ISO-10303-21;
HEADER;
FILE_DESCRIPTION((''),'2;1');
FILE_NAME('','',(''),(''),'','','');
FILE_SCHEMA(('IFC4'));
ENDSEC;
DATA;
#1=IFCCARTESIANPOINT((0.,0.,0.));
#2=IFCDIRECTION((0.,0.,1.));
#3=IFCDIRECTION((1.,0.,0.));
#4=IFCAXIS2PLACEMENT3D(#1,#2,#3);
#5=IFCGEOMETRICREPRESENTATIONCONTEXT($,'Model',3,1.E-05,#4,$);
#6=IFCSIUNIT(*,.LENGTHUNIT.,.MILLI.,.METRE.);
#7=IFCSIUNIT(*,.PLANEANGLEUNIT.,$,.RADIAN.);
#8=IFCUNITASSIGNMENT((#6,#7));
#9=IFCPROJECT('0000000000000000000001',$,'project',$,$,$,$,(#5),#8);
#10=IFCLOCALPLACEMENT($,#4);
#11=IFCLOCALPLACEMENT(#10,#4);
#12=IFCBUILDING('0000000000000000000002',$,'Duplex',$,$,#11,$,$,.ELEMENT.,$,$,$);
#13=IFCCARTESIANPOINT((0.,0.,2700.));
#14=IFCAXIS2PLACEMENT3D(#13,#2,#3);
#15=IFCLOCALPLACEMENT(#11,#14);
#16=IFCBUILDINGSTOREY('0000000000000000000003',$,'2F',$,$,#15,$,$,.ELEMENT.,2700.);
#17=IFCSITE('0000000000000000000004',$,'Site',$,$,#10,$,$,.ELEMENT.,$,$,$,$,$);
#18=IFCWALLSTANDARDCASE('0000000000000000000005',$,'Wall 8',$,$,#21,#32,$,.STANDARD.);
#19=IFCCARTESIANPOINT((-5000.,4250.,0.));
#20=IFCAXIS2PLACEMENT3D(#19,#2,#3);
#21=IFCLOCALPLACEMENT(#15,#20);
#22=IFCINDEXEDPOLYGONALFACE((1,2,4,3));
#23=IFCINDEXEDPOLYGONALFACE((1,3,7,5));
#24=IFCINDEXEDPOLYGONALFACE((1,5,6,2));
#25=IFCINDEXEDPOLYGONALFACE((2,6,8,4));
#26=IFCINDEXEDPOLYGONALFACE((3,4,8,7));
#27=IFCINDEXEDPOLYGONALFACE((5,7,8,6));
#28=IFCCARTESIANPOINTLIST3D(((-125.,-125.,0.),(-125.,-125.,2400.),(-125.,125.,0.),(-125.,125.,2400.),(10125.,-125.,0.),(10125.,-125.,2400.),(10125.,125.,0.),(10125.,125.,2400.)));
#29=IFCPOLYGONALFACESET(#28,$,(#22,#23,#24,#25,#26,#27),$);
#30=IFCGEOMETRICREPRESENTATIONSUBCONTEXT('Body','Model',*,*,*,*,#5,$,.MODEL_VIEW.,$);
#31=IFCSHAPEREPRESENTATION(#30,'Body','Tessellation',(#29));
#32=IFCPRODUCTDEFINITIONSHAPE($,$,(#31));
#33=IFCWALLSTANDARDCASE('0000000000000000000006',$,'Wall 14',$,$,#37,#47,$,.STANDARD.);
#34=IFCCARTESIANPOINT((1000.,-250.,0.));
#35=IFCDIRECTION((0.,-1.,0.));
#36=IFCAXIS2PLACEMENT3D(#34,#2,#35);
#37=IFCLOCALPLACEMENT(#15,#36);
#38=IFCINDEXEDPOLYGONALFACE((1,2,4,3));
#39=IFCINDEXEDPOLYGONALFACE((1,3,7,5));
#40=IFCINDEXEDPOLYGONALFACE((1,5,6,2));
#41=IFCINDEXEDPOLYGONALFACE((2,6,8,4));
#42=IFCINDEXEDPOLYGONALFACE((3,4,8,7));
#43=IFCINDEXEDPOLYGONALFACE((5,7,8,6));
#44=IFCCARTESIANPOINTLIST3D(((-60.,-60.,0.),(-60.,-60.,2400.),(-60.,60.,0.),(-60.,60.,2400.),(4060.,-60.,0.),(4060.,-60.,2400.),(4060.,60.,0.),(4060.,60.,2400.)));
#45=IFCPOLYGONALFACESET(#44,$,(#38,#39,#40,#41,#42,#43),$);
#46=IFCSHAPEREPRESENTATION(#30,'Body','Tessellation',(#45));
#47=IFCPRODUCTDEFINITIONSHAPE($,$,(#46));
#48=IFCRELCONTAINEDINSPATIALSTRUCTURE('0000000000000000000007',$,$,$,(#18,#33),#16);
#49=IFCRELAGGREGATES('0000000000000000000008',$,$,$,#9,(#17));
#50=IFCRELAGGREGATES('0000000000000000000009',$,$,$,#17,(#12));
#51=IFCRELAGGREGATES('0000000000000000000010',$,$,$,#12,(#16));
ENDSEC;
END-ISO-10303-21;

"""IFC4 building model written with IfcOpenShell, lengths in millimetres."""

from ifc_helpers import new_model, si_unit, frame, frame_2d, origin, origin_with_axes, place, context, subcontext, project, spatial, rectangle, extrude, element, save


model = new_model("IFC4")

# Units and contexts
model_context = context("Model", 3, precision=1e-05, world=origin_with_axes())
body_context = subcontext(model_context, "Body", "Model", "MODEL_VIEW")
ifc_project = project(units=[si_unit("LENGTHUNIT", "METRE", prefix="MILLI"), si_unit("PLANEANGLEUNIT", "RADIAN")], contexts=[model_context])

# Site, building, storey
site_placement = place(None, origin_with_axes())
site = spatial("IfcSite", under=ifc_project, at=site_placement, Name="Site", CompositionType="ELEMENT")
building_placement = place(site_placement, origin_with_axes())
building = spatial("IfcBuilding", under=site, at=building_placement, Name="Duplex", CompositionType="ELEMENT")
storey_placement = place(building_placement, frame((0.0, 0.0, 2700.0), z_axis=(0.0, 0.0, 1.0), x_axis=(1.0, 0.0, 0.0)))
storey = spatial("IfcBuildingStorey", under=building, at=storey_placement, Name="2F", CompositionType="ELEMENT", Elevation=2700.0)

# Wall
wall_1_placement = place(storey_placement, frame((-5000.0, 4250.0, 0.0), z_axis=(0.0, 0.0, 1.0), x_axis=(1.0, 0.0, 0.0)))
element("IfcWallStandardCase", 1, at=wall_1_placement, inside=storey, Name="Wall 8", PredefinedType="STANDARD", context=body_context, shape_type="SweptSolid", body=[
    extrude(rectangle(XDim=10250.0, YDim=250.0, at=frame_2d((5000.0, 0.0))), origin(), (0.0, 0.0, 1.0), 2400.0),
])

# Wall
wall_2_placement = place(storey_placement, frame((1000.0, -250.0, 0.0), z_axis=(0.0, 0.0, 1.0), x_axis=(0.0, -1.0, 0.0)))
element("IfcWallStandardCase", 2, at=wall_2_placement, inside=storey, Name="Wall 14", PredefinedType="STANDARD", context=body_context, shape_type="SweptSolid", body=[
    extrude(rectangle(XDim=4120.0, YDim=120.0, at=frame_2d((2000.0, 0.0))), origin(), (0.0, 0.0, 1.0), 2400.0),
])

save(model, "model.ifc")
